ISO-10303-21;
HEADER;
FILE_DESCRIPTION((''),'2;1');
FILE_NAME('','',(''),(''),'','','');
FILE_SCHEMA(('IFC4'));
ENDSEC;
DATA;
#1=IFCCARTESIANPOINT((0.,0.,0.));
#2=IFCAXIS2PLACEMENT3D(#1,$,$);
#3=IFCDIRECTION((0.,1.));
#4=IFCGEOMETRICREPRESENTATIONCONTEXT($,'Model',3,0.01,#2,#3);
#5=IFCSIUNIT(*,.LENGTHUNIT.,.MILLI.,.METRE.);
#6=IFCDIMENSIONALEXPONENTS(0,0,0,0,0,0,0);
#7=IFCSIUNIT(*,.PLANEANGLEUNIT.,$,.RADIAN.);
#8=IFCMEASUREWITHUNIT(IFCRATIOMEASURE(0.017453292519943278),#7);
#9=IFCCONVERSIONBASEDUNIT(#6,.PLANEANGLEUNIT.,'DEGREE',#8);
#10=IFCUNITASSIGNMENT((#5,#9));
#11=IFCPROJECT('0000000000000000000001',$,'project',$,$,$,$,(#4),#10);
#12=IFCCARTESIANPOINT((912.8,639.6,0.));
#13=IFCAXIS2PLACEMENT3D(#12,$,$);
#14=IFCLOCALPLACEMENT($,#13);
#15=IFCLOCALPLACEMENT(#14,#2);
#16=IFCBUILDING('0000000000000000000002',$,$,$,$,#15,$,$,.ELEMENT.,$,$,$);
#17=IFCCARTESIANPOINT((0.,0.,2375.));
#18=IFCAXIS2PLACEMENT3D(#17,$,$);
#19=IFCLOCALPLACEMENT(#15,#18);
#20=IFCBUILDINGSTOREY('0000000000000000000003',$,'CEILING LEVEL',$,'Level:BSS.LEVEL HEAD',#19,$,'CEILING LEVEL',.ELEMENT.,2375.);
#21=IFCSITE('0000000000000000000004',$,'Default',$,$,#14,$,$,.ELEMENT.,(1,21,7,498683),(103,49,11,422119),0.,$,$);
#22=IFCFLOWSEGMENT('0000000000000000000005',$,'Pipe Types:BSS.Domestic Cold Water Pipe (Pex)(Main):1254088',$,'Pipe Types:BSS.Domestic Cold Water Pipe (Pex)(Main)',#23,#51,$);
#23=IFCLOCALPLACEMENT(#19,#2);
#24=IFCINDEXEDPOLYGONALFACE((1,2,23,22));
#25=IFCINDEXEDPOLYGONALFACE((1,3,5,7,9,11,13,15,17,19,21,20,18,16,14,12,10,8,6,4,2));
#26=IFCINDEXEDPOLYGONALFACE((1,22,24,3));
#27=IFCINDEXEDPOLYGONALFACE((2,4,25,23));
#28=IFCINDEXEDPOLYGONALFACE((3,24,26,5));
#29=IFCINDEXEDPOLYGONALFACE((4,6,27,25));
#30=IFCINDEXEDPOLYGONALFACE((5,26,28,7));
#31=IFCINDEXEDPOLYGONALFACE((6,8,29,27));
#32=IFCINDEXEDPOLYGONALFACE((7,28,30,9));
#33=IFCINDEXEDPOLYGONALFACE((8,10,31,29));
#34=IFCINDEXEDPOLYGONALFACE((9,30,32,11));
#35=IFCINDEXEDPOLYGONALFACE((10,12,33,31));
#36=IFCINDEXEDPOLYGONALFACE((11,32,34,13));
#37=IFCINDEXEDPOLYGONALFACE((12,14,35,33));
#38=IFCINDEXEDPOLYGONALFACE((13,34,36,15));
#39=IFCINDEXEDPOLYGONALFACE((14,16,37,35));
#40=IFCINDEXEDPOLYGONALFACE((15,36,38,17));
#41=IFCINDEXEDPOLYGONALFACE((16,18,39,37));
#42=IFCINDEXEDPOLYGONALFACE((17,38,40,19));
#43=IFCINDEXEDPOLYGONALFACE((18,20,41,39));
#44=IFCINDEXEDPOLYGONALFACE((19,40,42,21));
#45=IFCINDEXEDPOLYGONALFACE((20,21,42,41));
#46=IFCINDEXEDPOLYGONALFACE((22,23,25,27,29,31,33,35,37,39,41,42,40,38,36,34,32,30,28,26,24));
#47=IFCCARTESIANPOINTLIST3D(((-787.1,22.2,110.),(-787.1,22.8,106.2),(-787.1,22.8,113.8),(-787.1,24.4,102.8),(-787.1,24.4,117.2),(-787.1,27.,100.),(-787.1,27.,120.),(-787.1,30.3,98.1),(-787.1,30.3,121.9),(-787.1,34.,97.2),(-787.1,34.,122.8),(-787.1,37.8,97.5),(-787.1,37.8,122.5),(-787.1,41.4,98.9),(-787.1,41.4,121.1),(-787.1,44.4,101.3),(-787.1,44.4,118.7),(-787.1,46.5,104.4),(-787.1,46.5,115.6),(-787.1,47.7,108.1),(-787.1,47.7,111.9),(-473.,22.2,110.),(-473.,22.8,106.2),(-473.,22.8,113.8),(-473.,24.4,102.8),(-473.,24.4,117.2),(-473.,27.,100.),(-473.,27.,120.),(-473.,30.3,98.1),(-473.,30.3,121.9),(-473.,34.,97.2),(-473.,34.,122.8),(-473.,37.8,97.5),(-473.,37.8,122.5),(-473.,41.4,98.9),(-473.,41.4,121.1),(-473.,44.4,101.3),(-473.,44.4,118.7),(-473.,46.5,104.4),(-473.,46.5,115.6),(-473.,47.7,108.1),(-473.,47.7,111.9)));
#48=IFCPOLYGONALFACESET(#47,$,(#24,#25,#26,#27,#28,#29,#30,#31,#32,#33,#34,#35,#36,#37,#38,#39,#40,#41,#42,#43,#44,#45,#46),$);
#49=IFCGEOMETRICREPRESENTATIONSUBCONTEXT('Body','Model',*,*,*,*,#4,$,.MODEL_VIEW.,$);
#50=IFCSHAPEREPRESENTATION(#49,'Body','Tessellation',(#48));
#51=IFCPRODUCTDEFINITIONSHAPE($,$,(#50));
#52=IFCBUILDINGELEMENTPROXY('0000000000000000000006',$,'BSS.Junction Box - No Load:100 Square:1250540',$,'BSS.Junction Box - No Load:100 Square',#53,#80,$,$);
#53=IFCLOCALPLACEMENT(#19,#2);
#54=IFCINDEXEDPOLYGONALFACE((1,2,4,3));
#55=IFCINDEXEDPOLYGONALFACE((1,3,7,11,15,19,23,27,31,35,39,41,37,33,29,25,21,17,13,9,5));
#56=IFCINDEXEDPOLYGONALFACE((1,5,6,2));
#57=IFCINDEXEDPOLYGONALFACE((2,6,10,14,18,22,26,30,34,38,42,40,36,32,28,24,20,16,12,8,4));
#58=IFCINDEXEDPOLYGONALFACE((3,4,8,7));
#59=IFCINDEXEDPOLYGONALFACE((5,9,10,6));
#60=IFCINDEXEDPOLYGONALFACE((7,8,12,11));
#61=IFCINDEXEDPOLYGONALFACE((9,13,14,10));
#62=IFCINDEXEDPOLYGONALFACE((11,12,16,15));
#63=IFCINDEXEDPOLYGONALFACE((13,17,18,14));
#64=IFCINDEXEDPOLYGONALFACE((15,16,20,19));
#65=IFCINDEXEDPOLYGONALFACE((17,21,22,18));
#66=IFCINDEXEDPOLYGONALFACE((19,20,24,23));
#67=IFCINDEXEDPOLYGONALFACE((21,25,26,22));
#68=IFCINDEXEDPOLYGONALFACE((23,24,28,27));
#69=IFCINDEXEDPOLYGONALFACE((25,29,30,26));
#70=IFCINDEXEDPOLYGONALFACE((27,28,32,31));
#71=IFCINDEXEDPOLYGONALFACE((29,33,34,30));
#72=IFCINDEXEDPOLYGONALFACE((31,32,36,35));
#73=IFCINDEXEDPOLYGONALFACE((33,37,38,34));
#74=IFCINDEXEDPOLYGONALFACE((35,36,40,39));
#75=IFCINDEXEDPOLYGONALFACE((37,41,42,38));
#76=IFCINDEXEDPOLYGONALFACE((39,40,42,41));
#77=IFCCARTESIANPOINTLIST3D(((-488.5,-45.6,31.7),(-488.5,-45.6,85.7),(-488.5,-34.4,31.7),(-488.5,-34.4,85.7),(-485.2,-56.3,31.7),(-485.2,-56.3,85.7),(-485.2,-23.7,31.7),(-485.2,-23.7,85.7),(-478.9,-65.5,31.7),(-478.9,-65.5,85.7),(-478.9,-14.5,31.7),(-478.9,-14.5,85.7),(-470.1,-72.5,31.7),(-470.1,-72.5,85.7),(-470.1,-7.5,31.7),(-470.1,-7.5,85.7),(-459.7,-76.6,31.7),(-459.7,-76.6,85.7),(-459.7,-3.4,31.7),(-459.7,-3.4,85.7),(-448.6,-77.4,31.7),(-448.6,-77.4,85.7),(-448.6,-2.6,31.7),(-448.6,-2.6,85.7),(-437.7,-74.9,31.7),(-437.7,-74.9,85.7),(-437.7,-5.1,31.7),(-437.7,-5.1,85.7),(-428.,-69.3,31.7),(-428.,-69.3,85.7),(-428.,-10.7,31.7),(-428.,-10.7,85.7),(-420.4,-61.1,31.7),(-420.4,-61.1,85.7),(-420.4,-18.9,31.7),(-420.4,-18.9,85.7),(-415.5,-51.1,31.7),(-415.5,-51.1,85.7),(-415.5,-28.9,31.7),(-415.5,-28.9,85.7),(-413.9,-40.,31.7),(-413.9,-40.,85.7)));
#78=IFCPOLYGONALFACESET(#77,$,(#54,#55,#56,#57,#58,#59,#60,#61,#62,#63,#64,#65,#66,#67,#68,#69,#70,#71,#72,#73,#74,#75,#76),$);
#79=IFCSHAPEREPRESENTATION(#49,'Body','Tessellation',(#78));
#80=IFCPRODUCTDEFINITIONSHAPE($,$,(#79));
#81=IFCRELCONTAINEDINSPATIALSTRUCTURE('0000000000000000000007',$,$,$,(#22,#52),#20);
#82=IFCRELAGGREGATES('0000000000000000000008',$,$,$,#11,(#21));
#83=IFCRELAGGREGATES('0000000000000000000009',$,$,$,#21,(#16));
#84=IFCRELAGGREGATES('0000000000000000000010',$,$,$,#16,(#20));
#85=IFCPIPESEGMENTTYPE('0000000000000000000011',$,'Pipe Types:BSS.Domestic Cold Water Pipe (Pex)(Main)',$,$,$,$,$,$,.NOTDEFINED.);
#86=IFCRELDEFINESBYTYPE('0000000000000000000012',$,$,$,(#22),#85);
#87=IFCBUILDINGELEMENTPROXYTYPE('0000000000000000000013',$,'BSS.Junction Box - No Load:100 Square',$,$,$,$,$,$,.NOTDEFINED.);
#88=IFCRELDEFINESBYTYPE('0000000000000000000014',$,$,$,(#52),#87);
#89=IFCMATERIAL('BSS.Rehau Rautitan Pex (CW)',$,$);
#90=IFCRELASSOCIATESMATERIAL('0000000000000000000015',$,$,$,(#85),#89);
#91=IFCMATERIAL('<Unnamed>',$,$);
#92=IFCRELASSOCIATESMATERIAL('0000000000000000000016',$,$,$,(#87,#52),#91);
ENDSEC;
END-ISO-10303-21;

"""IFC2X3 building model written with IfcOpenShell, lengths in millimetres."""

from ifc_helpers import new_model, entity, si_unit, converted_unit, direction, frame, frame_2d, origin, place, context, subcontext, project, spatial, circle, extrude, source, transform, mapped, material, type_object, type_shapes, element, save


model = new_model("IFC2X3")

# Units and contexts
model_context = context("Model", 3, precision=0.01, world=origin(), true_north=direction((0.0, 1.0)))
body_context = subcontext(model_context, "Body", "Model", "MODEL_VIEW")
ifc_project = project(units=[si_unit("LENGTHUNIT", "METRE", prefix="MILLI"), converted_unit("PLANEANGLEUNIT", "DEGREE", entity("IfcRatioMeasure", 0.017453292519943278), si_unit("PLANEANGLEUNIT", "RADIAN"), dimensions=[0, 0, 0, 0, 0, 0, 0])], contexts=[model_context])

# Site, building, storey
site_placement = place(None, frame((912.8, 639.6, 0.0)))
site = spatial("IfcSite", under=ifc_project, at=site_placement, Name="Default", CompositionType="ELEMENT", RefLatitude=(1, 21, 7, 498683), RefLongitude=(103, 49, 11, 422119), RefElevation=0.0)
building_placement = place(site_placement, origin())
building = spatial("IfcBuilding", under=site, at=building_placement, CompositionType="ELEMENT")
storey_placement = place(building_placement, frame((0.0, 0.0, 2375.0)))
storey = spatial("IfcBuildingStorey", under=building, at=storey_placement, Name="CEILING LEVEL", ObjectType="Level:BSS.LEVEL HEAD", LongName="CEILING LEVEL", CompositionType="ELEMENT", Elevation=2375.0)

# Flow segment
ifc_material_1 = material(Name="BSS.Rehau Rautitan Pex (CW)")
pipe_segment_type_1 = type_object("IfcPipeSegmentType", Name="Pipe Types:BSS.Domestic Cold Water Pipe (Pex)(Main)", PredefinedType="NOTDEFINED", material=ifc_material_1)
flow_segment_1_placement = place(storey_placement, origin())
element("IfcFlowSegment", 1, at=flow_segment_1_placement, inside=storey, type_object=pipe_segment_type_1, Name="Pipe Types:BSS.Domestic Cold Water Pipe (Pex)(Main):1254088", ObjectType="Pipe Types:BSS.Domestic Cold Water Pipe (Pex)(Main)", context=body_context, shape_type="SweptSolid", body=[
    extrude(circle(Radius=12.8, at=frame_2d((0.0, 0.0), x_axis=(1.0, 0.0))), frame((-787.1, 35.0, 110.0), z_axis=(1.0, 0.0, 0.0), x_axis=(0.0, -1.0, 0.0)), (0.0, 0.0, 1.0), 314.1),
])

# Building element proxy
ifc_material_2 = material(Name="<Unnamed>")
building_element_proxy_type = type_object("IfcBuildingElementProxyType", Name="BSS.Junction Box - No Load:100 Square", PredefinedType="NOTDEFINED", material=ifc_material_2)
shared_shape = source(origin(), body_context, "Body", "SweptSolid", [
    extrude(circle(Radius=37.5, at=frame_2d((0.0, 0.0), x_axis=(1.0, 0.0))), origin(), (0.0, 0.0, 1.0), 54.0),
])
type_shapes(building_element_proxy_type, [shared_shape])
proxy_placement = place(storey_placement, frame((-451.4, -40.0, 31.7)))
element("IfcBuildingElementProxy", 2, at=proxy_placement, inside=storey, type_object=building_element_proxy_type, material=ifc_material_2, Name="BSS.Junction Box - No Load:100 Square:1250540", ObjectType="BSS.Junction Box - No Load:100 Square", context=body_context, shape_type="MappedRepresentation", body=[
    mapped(shared_shape, transform((0.0, 0.0, 0.0), scale=1.0)),
])

save(model, "model.ifc")
